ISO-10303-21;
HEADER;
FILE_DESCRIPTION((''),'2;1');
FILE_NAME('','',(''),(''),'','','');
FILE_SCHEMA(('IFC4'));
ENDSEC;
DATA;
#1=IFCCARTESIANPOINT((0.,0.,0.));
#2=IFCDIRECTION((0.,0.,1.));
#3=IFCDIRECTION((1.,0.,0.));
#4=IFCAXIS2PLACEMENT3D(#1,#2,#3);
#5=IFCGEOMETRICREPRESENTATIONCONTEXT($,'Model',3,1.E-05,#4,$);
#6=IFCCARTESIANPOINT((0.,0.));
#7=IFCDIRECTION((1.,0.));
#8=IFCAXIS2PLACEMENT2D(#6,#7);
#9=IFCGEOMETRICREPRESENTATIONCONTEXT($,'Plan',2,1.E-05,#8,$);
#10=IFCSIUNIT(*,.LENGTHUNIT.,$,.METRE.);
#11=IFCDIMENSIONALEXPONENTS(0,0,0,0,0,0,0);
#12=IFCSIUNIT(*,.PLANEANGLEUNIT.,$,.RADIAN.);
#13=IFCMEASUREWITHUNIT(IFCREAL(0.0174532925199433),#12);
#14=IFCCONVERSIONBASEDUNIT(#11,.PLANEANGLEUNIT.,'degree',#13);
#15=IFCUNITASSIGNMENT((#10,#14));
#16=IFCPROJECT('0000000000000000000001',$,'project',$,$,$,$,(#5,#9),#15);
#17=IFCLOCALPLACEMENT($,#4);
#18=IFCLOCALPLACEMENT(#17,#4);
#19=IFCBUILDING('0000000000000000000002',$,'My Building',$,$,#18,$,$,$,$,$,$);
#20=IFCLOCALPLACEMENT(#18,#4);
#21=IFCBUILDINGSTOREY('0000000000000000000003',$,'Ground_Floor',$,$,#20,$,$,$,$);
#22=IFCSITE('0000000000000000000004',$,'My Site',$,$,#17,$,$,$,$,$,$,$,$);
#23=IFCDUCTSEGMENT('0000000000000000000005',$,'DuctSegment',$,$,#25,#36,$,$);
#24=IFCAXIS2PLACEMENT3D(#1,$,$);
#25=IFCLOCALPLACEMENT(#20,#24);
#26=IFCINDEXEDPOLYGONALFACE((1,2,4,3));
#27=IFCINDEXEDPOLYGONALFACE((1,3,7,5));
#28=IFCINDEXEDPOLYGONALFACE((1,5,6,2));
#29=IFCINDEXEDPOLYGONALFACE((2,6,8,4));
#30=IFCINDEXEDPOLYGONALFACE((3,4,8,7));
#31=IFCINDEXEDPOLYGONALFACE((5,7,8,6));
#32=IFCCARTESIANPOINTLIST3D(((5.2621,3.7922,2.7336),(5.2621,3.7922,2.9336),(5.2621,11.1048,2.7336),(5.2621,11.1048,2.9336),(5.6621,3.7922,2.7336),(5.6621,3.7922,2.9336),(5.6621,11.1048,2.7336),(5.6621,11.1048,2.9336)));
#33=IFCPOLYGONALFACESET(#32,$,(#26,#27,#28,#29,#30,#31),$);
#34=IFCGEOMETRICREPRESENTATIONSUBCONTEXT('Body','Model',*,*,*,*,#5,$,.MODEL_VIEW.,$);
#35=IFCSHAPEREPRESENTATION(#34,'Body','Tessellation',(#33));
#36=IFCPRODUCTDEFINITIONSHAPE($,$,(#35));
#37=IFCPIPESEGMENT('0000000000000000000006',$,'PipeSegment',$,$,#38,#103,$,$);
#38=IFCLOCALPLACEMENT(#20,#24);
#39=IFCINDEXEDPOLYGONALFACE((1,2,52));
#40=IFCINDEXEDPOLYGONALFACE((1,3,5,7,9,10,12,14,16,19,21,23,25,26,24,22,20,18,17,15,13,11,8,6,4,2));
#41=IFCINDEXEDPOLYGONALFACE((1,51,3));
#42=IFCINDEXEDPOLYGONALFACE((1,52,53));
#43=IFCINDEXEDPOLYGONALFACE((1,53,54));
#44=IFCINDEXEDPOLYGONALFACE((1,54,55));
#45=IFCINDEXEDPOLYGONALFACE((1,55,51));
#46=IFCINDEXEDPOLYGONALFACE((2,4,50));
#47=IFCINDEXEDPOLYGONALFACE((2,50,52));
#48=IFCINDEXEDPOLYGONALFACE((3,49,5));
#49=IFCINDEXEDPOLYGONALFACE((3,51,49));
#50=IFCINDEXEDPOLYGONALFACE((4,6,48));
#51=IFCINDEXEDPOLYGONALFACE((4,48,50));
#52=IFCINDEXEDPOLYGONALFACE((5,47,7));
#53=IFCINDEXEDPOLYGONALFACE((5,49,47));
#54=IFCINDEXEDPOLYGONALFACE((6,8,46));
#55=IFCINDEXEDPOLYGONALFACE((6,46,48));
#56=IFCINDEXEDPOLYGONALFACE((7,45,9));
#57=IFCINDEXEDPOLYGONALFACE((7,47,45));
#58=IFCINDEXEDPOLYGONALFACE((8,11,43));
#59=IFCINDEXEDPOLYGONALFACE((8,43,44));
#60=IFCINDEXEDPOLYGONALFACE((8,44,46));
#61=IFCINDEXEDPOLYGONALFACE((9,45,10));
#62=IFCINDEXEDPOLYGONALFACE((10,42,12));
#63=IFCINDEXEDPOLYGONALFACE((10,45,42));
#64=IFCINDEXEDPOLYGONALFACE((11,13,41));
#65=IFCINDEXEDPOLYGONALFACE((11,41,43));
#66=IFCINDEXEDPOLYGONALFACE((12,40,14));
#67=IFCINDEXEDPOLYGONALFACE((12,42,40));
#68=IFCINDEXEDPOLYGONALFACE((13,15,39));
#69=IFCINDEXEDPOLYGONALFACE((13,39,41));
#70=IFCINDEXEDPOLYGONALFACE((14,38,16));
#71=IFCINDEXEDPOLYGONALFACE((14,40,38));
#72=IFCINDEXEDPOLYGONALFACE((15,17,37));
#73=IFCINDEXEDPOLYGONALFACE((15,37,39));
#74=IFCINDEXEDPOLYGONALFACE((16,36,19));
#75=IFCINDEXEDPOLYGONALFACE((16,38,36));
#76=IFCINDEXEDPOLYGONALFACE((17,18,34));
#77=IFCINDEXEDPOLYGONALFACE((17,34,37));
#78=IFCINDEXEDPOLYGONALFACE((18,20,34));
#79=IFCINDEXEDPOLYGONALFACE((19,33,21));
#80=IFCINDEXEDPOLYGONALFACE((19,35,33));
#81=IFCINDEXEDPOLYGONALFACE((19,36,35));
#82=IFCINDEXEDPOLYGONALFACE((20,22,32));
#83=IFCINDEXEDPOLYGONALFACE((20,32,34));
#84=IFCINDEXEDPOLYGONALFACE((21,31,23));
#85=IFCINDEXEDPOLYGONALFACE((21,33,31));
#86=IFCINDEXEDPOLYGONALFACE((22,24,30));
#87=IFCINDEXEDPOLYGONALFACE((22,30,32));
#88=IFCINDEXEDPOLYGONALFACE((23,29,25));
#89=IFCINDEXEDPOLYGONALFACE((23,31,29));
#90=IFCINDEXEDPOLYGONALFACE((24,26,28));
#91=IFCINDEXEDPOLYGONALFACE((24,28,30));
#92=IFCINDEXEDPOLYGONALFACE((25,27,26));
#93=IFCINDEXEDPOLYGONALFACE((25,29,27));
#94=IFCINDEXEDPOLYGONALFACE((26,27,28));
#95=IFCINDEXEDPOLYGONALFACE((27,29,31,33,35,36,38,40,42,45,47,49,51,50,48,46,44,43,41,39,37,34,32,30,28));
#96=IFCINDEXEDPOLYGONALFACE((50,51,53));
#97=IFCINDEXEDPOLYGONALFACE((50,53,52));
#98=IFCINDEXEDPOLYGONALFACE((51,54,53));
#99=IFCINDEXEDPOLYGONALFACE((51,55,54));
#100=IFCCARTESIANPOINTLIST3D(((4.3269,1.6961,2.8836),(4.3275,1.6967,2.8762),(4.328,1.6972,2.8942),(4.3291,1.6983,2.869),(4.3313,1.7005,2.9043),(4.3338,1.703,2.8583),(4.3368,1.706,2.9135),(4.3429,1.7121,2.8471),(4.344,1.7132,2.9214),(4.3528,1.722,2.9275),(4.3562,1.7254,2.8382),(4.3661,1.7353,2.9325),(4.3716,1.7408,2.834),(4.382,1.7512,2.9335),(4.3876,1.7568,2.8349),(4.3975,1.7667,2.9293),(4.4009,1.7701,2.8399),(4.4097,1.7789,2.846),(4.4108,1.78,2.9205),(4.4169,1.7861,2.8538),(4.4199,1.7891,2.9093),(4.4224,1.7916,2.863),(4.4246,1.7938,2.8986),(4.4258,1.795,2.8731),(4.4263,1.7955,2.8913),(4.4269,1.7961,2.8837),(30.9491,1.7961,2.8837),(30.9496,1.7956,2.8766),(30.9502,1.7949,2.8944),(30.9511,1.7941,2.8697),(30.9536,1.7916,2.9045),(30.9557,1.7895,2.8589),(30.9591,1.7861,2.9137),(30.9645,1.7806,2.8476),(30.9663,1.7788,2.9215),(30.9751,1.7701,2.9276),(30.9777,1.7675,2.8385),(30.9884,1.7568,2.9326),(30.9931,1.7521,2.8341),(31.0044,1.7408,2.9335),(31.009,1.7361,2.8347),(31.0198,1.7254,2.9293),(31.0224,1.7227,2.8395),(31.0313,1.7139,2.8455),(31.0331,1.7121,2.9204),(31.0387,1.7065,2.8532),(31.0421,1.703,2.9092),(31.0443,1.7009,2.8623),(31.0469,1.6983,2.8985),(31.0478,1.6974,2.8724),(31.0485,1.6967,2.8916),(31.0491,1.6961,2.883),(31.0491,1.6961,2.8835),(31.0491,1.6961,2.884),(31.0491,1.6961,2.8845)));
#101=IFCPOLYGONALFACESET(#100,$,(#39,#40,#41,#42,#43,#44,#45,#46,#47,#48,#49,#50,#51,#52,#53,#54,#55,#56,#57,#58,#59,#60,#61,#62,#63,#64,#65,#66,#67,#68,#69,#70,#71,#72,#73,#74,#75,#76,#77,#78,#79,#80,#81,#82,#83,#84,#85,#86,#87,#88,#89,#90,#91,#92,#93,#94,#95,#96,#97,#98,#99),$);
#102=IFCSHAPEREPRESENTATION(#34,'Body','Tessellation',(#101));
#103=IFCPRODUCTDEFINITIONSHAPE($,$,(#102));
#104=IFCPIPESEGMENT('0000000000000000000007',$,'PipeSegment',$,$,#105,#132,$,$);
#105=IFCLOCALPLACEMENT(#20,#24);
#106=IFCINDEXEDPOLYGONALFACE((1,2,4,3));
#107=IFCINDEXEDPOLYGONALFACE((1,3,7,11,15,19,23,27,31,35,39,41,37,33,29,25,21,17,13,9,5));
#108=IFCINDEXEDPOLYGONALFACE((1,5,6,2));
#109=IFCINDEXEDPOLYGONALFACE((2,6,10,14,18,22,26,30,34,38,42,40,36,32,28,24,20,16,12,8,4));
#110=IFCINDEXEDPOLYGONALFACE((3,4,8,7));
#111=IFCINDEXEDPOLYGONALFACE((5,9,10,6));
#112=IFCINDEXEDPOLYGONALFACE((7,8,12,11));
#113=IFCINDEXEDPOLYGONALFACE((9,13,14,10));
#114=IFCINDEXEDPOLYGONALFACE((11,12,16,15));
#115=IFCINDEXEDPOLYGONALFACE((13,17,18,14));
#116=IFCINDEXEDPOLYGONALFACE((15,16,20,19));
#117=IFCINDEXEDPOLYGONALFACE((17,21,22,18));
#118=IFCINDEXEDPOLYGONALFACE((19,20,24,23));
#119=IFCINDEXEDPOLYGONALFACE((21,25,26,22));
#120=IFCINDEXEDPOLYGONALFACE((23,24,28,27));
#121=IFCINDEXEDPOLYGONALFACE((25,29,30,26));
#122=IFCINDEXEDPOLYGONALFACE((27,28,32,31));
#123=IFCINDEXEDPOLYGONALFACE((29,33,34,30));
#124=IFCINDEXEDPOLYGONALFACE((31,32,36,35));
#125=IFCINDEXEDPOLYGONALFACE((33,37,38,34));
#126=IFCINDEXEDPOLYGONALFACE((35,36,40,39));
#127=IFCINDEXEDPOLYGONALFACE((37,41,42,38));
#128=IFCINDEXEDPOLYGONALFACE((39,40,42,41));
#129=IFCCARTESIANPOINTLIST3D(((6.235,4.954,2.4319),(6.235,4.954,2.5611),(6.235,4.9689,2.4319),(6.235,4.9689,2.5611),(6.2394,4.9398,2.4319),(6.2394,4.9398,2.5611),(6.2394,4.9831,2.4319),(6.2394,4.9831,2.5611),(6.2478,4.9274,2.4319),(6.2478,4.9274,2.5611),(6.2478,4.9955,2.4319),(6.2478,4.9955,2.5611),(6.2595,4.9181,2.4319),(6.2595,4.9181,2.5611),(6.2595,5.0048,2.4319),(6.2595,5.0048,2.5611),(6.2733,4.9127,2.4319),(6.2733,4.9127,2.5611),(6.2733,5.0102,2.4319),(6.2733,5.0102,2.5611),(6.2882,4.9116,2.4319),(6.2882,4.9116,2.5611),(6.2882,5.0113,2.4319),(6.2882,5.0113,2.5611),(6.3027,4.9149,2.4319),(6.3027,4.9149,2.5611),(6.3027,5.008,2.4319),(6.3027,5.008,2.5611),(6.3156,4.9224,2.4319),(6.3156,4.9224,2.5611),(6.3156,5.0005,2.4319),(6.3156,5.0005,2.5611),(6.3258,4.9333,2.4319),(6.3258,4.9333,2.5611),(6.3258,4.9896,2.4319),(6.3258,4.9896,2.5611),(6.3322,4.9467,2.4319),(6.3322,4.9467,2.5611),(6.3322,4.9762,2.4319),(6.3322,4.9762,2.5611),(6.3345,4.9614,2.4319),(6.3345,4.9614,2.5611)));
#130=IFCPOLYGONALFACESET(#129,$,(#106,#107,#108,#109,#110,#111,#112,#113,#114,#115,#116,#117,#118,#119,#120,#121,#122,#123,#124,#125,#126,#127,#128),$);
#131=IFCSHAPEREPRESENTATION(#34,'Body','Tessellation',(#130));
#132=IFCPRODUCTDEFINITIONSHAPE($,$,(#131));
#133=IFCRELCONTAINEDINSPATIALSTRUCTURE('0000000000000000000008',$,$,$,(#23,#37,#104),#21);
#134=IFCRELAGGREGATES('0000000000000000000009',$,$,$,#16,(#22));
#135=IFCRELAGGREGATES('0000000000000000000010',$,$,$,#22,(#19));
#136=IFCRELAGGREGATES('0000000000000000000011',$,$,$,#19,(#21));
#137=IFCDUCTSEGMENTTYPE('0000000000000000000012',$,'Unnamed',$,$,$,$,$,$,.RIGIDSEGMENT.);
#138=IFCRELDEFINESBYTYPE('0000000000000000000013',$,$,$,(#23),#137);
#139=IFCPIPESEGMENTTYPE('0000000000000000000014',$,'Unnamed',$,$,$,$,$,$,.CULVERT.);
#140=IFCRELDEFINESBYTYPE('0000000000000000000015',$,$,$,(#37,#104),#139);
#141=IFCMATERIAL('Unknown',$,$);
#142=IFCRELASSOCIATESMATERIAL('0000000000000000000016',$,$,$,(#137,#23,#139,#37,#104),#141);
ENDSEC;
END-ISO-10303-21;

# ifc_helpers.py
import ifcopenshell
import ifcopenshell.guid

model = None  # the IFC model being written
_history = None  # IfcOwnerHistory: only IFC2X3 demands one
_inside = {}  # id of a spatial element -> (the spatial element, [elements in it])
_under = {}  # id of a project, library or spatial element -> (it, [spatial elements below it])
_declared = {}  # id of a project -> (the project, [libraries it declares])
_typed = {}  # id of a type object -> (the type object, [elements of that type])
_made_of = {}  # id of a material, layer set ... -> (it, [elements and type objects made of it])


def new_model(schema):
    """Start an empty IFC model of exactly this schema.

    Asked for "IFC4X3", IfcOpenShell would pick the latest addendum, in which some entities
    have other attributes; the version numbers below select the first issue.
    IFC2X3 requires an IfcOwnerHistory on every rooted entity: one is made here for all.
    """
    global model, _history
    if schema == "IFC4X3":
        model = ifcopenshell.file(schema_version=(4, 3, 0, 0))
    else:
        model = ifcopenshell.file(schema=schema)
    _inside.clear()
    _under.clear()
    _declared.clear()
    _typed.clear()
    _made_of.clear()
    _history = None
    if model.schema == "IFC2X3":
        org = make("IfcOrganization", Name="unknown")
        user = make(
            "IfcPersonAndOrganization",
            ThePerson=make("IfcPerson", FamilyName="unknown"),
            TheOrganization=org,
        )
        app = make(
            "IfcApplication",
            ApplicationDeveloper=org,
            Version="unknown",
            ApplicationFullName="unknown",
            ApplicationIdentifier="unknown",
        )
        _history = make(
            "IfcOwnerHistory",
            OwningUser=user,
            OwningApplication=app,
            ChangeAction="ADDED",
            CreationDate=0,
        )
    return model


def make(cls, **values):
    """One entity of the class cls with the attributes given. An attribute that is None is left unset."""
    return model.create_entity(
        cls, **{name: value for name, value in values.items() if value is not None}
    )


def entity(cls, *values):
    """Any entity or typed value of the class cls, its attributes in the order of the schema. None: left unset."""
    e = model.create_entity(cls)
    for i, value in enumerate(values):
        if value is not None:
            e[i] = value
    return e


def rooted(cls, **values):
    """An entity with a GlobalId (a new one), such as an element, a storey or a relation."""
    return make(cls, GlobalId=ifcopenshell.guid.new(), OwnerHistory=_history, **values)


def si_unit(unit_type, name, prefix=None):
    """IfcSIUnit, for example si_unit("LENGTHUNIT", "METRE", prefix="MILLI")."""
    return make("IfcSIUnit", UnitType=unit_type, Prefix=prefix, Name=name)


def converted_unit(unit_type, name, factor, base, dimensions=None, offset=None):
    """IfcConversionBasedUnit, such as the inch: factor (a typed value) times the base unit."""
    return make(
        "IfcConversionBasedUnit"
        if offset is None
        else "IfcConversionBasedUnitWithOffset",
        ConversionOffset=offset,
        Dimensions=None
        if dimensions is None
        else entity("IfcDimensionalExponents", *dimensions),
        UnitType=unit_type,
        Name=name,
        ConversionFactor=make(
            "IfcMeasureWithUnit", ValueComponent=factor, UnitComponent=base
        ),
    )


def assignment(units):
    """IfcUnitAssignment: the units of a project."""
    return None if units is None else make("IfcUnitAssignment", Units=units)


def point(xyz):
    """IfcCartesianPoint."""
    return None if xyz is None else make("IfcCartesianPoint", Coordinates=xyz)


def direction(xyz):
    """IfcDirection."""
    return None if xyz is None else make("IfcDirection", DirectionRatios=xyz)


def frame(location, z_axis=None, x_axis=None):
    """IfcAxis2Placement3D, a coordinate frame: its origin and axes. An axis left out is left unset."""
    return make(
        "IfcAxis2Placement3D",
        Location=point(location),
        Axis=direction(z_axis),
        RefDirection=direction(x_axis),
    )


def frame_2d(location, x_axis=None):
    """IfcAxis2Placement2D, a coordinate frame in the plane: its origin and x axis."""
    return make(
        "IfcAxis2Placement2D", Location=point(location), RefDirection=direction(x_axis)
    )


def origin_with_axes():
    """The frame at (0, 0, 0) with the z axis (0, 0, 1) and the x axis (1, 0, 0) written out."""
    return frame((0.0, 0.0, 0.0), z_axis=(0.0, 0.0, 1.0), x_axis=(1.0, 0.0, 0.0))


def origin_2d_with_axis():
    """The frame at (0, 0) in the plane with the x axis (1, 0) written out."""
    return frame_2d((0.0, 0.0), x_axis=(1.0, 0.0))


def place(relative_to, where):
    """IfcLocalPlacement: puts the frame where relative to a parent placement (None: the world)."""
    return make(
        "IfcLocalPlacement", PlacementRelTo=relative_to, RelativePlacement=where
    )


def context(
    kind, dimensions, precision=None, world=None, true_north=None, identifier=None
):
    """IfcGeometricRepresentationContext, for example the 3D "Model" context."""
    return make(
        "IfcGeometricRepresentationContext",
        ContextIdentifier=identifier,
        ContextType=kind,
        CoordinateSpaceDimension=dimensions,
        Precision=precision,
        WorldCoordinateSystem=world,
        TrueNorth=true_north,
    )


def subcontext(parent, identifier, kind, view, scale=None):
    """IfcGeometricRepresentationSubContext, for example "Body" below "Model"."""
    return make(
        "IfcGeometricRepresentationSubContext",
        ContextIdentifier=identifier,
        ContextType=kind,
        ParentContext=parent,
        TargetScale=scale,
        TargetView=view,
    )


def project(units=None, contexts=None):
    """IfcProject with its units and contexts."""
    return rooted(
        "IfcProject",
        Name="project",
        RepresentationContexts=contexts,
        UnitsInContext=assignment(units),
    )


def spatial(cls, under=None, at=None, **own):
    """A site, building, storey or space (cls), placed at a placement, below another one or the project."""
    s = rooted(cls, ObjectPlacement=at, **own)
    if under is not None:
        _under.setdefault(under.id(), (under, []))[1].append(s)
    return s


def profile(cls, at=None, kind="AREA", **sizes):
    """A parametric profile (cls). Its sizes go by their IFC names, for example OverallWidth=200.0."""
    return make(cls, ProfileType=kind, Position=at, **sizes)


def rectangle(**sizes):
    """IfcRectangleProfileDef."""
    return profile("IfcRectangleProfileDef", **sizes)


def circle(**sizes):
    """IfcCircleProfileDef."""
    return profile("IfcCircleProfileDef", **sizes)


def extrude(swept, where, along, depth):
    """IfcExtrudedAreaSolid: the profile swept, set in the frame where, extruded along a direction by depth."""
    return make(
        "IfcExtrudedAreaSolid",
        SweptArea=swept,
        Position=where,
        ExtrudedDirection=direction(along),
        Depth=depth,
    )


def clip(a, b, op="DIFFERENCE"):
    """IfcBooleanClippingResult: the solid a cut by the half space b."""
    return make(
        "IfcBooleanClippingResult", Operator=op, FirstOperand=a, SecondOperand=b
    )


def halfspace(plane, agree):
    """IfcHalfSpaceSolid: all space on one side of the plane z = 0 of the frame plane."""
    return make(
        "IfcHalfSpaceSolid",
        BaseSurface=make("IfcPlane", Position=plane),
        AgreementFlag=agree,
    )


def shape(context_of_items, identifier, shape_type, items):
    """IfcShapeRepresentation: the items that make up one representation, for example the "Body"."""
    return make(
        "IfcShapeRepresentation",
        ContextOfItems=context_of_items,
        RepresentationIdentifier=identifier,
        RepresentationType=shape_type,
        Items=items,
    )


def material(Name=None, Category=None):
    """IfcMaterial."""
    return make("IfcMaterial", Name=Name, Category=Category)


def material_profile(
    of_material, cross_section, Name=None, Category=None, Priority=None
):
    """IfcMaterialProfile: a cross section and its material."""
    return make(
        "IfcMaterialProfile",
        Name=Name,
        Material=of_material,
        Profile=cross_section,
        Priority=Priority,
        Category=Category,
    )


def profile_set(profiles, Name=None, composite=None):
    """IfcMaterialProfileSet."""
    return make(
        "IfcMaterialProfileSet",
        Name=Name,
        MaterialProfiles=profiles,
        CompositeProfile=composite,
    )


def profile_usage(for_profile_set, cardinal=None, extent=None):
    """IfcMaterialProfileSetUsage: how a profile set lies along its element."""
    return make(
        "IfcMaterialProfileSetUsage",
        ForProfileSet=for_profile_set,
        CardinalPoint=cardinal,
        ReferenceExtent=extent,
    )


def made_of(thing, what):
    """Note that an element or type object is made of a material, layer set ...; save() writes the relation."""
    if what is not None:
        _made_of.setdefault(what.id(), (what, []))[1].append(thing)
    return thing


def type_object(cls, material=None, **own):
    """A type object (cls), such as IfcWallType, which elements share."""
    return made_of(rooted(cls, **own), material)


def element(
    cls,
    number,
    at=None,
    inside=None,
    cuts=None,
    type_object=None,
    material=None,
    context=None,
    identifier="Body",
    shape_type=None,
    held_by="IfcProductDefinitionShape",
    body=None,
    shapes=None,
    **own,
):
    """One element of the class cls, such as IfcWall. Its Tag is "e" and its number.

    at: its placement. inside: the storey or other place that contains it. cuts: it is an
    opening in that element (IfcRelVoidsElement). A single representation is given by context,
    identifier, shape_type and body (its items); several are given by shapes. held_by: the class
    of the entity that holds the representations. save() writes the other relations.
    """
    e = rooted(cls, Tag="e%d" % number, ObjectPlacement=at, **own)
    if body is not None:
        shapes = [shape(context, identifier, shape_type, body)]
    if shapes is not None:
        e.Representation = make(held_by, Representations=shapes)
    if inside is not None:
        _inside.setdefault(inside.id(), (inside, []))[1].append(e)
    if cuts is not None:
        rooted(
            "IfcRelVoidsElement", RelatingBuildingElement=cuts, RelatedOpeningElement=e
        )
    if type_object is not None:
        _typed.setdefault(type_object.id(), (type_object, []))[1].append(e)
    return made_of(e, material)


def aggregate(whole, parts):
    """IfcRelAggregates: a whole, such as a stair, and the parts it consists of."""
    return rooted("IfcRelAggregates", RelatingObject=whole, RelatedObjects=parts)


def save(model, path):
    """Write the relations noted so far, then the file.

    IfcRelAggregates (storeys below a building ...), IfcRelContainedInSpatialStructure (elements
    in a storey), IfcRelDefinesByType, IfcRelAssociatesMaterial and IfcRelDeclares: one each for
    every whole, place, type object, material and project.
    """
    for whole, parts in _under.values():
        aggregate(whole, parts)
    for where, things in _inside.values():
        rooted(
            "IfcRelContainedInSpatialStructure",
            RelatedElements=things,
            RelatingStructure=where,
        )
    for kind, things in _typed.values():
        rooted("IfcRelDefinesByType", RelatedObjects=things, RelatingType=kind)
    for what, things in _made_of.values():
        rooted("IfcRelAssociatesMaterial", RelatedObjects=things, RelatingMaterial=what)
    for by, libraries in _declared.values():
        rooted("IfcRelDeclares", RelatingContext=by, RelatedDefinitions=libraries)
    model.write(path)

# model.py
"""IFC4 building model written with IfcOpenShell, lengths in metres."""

from ifc_helpers import new_model, entity, si_unit, converted_unit, frame, origin_with_axes, origin_2d_with_axis, place, context, subcontext, project, spatial, rectangle, circle, extrude, clip, halfspace, material, material_profile, profile_set, profile_usage, type_object, element, save


model = new_model("IFC4")

# Units and contexts
model_context = context("Model", 3, precision=1e-05, world=origin_with_axes())
plan_context = context("Plan", 2, precision=1e-05, world=origin_2d_with_axis())
body_context_1 = subcontext(model_context, "Body", "Model", "MODEL_VIEW")
ifc_project = project(units=[si_unit("LENGTHUNIT", "METRE"), converted_unit("PLANEANGLEUNIT", "degree", entity("IfcReal", 0.0174532925199433), si_unit("PLANEANGLEUNIT", "RADIAN"), dimensions=[0, 0, 0, 0, 0, 0, 0])], contexts=[model_context, plan_context])

# Site, building, storey
site_placement = place(None, origin_with_axes())
site = spatial("IfcSite", under=ifc_project, at=site_placement, Name="My Site")
building_placement = place(site_placement, origin_with_axes())
building = spatial("IfcBuilding", under=site, at=building_placement, Name="My Building")
storey_placement = place(building_placement, origin_with_axes())
storey = spatial("IfcBuildingStorey", under=building, at=storey_placement, Name="Ground_Floor")

# Shared definitions
ifc_material = material(Name="Unknown")

# Duct segment
ifc_material_profile_1 = material_profile(ifc_material, rectangle(XDim=0.4, YDim=0.2))
ifc_profile_set_1 = profile_set([ifc_material_profile_1])
ifc_profile_usage_1 = profile_usage(ifc_profile_set_1, cardinal=5)
duct_segment_type = type_object("IfcDuctSegmentType", Name="Unnamed", PredefinedType="RIGIDSEGMENT", material=ifc_profile_set_1)
duct_segment_placement = place(storey_placement, frame((5.4621, 3.7922, 2.8336), z_axis=(0.0, 1.0, 0.0), x_axis=(-1.0, 0.0, 0.0)))
element("IfcDuctSegment", 1, at=duct_segment_placement, inside=storey, type_object=duct_segment_type, material=ifc_profile_usage_1, Name="DuctSegment", context=body_context_1, shape_type="SweptSolid", body=[
    extrude(rectangle(XDim=0.4, YDim=0.2), origin_with_axes(), (0.0, 0.0, 1.0), 7.3126),
])

# Pipe segments
ifc_material_profile_2 = material_profile(ifc_material, circle(Radius=0.05))
ifc_profile_set_2 = profile_set([ifc_material_profile_2])
ifc_profile_usage_2 = profile_usage(ifc_profile_set_2, cardinal=5)
pipe_segment_type = type_object("IfcPipeSegmentType", Name="Unnamed", PredefinedType="CULVERT", material=ifc_profile_set_2)
pipe_segment_1_placement = place(storey_placement, frame((4.3269, 1.7461, 2.8837), z_axis=(1.0, 0.0, 0.0), x_axis=(0.0, 1.0, 0.0)))
element("IfcPipeSegment", 2, at=pipe_segment_1_placement, inside=storey, type_object=pipe_segment_type, material=ifc_profile_usage_2, Name="PipeSegment", context=body_context_1, shape_type="Clipping", body=[
    clip(clip(extrude(circle(Radius=0.05), origin_with_axes(), (0.0, 0.0, 1.0), 26.7222), halfspace(frame((-0.05, 0.0, 26.7222), z_axis=(0.707102, 0.0, 0.707112), x_axis=(-0.000001, -1.0, 0.0)), False)), halfspace(frame((-0.05, 0.0, 0.0), z_axis=(0.707108, 0.0, -0.707106), x_axis=(0.0, -1.0, 0.0)), False)),
])
ifc_profile_usage_3 = profile_usage(ifc_profile_set_2, cardinal=5)
pipe_segment_2_placement = place(storey_placement, frame((6.2845, 4.9614, 2.5611), z_axis=(0.0, 0.0, -1.0), x_axis=(1.0, 0.0, 0.0)))
element("IfcPipeSegment", 3, at=pipe_segment_2_placement, inside=storey, type_object=pipe_segment_type, material=ifc_profile_usage_3, Name="PipeSegment", context=body_context_1, shape_type="SweptSolid", body=[
    extrude(circle(Radius=0.05), origin_with_axes(), (0.0, 0.0, 1.0), 0.1291),
])

save(model, "model.ifc")
